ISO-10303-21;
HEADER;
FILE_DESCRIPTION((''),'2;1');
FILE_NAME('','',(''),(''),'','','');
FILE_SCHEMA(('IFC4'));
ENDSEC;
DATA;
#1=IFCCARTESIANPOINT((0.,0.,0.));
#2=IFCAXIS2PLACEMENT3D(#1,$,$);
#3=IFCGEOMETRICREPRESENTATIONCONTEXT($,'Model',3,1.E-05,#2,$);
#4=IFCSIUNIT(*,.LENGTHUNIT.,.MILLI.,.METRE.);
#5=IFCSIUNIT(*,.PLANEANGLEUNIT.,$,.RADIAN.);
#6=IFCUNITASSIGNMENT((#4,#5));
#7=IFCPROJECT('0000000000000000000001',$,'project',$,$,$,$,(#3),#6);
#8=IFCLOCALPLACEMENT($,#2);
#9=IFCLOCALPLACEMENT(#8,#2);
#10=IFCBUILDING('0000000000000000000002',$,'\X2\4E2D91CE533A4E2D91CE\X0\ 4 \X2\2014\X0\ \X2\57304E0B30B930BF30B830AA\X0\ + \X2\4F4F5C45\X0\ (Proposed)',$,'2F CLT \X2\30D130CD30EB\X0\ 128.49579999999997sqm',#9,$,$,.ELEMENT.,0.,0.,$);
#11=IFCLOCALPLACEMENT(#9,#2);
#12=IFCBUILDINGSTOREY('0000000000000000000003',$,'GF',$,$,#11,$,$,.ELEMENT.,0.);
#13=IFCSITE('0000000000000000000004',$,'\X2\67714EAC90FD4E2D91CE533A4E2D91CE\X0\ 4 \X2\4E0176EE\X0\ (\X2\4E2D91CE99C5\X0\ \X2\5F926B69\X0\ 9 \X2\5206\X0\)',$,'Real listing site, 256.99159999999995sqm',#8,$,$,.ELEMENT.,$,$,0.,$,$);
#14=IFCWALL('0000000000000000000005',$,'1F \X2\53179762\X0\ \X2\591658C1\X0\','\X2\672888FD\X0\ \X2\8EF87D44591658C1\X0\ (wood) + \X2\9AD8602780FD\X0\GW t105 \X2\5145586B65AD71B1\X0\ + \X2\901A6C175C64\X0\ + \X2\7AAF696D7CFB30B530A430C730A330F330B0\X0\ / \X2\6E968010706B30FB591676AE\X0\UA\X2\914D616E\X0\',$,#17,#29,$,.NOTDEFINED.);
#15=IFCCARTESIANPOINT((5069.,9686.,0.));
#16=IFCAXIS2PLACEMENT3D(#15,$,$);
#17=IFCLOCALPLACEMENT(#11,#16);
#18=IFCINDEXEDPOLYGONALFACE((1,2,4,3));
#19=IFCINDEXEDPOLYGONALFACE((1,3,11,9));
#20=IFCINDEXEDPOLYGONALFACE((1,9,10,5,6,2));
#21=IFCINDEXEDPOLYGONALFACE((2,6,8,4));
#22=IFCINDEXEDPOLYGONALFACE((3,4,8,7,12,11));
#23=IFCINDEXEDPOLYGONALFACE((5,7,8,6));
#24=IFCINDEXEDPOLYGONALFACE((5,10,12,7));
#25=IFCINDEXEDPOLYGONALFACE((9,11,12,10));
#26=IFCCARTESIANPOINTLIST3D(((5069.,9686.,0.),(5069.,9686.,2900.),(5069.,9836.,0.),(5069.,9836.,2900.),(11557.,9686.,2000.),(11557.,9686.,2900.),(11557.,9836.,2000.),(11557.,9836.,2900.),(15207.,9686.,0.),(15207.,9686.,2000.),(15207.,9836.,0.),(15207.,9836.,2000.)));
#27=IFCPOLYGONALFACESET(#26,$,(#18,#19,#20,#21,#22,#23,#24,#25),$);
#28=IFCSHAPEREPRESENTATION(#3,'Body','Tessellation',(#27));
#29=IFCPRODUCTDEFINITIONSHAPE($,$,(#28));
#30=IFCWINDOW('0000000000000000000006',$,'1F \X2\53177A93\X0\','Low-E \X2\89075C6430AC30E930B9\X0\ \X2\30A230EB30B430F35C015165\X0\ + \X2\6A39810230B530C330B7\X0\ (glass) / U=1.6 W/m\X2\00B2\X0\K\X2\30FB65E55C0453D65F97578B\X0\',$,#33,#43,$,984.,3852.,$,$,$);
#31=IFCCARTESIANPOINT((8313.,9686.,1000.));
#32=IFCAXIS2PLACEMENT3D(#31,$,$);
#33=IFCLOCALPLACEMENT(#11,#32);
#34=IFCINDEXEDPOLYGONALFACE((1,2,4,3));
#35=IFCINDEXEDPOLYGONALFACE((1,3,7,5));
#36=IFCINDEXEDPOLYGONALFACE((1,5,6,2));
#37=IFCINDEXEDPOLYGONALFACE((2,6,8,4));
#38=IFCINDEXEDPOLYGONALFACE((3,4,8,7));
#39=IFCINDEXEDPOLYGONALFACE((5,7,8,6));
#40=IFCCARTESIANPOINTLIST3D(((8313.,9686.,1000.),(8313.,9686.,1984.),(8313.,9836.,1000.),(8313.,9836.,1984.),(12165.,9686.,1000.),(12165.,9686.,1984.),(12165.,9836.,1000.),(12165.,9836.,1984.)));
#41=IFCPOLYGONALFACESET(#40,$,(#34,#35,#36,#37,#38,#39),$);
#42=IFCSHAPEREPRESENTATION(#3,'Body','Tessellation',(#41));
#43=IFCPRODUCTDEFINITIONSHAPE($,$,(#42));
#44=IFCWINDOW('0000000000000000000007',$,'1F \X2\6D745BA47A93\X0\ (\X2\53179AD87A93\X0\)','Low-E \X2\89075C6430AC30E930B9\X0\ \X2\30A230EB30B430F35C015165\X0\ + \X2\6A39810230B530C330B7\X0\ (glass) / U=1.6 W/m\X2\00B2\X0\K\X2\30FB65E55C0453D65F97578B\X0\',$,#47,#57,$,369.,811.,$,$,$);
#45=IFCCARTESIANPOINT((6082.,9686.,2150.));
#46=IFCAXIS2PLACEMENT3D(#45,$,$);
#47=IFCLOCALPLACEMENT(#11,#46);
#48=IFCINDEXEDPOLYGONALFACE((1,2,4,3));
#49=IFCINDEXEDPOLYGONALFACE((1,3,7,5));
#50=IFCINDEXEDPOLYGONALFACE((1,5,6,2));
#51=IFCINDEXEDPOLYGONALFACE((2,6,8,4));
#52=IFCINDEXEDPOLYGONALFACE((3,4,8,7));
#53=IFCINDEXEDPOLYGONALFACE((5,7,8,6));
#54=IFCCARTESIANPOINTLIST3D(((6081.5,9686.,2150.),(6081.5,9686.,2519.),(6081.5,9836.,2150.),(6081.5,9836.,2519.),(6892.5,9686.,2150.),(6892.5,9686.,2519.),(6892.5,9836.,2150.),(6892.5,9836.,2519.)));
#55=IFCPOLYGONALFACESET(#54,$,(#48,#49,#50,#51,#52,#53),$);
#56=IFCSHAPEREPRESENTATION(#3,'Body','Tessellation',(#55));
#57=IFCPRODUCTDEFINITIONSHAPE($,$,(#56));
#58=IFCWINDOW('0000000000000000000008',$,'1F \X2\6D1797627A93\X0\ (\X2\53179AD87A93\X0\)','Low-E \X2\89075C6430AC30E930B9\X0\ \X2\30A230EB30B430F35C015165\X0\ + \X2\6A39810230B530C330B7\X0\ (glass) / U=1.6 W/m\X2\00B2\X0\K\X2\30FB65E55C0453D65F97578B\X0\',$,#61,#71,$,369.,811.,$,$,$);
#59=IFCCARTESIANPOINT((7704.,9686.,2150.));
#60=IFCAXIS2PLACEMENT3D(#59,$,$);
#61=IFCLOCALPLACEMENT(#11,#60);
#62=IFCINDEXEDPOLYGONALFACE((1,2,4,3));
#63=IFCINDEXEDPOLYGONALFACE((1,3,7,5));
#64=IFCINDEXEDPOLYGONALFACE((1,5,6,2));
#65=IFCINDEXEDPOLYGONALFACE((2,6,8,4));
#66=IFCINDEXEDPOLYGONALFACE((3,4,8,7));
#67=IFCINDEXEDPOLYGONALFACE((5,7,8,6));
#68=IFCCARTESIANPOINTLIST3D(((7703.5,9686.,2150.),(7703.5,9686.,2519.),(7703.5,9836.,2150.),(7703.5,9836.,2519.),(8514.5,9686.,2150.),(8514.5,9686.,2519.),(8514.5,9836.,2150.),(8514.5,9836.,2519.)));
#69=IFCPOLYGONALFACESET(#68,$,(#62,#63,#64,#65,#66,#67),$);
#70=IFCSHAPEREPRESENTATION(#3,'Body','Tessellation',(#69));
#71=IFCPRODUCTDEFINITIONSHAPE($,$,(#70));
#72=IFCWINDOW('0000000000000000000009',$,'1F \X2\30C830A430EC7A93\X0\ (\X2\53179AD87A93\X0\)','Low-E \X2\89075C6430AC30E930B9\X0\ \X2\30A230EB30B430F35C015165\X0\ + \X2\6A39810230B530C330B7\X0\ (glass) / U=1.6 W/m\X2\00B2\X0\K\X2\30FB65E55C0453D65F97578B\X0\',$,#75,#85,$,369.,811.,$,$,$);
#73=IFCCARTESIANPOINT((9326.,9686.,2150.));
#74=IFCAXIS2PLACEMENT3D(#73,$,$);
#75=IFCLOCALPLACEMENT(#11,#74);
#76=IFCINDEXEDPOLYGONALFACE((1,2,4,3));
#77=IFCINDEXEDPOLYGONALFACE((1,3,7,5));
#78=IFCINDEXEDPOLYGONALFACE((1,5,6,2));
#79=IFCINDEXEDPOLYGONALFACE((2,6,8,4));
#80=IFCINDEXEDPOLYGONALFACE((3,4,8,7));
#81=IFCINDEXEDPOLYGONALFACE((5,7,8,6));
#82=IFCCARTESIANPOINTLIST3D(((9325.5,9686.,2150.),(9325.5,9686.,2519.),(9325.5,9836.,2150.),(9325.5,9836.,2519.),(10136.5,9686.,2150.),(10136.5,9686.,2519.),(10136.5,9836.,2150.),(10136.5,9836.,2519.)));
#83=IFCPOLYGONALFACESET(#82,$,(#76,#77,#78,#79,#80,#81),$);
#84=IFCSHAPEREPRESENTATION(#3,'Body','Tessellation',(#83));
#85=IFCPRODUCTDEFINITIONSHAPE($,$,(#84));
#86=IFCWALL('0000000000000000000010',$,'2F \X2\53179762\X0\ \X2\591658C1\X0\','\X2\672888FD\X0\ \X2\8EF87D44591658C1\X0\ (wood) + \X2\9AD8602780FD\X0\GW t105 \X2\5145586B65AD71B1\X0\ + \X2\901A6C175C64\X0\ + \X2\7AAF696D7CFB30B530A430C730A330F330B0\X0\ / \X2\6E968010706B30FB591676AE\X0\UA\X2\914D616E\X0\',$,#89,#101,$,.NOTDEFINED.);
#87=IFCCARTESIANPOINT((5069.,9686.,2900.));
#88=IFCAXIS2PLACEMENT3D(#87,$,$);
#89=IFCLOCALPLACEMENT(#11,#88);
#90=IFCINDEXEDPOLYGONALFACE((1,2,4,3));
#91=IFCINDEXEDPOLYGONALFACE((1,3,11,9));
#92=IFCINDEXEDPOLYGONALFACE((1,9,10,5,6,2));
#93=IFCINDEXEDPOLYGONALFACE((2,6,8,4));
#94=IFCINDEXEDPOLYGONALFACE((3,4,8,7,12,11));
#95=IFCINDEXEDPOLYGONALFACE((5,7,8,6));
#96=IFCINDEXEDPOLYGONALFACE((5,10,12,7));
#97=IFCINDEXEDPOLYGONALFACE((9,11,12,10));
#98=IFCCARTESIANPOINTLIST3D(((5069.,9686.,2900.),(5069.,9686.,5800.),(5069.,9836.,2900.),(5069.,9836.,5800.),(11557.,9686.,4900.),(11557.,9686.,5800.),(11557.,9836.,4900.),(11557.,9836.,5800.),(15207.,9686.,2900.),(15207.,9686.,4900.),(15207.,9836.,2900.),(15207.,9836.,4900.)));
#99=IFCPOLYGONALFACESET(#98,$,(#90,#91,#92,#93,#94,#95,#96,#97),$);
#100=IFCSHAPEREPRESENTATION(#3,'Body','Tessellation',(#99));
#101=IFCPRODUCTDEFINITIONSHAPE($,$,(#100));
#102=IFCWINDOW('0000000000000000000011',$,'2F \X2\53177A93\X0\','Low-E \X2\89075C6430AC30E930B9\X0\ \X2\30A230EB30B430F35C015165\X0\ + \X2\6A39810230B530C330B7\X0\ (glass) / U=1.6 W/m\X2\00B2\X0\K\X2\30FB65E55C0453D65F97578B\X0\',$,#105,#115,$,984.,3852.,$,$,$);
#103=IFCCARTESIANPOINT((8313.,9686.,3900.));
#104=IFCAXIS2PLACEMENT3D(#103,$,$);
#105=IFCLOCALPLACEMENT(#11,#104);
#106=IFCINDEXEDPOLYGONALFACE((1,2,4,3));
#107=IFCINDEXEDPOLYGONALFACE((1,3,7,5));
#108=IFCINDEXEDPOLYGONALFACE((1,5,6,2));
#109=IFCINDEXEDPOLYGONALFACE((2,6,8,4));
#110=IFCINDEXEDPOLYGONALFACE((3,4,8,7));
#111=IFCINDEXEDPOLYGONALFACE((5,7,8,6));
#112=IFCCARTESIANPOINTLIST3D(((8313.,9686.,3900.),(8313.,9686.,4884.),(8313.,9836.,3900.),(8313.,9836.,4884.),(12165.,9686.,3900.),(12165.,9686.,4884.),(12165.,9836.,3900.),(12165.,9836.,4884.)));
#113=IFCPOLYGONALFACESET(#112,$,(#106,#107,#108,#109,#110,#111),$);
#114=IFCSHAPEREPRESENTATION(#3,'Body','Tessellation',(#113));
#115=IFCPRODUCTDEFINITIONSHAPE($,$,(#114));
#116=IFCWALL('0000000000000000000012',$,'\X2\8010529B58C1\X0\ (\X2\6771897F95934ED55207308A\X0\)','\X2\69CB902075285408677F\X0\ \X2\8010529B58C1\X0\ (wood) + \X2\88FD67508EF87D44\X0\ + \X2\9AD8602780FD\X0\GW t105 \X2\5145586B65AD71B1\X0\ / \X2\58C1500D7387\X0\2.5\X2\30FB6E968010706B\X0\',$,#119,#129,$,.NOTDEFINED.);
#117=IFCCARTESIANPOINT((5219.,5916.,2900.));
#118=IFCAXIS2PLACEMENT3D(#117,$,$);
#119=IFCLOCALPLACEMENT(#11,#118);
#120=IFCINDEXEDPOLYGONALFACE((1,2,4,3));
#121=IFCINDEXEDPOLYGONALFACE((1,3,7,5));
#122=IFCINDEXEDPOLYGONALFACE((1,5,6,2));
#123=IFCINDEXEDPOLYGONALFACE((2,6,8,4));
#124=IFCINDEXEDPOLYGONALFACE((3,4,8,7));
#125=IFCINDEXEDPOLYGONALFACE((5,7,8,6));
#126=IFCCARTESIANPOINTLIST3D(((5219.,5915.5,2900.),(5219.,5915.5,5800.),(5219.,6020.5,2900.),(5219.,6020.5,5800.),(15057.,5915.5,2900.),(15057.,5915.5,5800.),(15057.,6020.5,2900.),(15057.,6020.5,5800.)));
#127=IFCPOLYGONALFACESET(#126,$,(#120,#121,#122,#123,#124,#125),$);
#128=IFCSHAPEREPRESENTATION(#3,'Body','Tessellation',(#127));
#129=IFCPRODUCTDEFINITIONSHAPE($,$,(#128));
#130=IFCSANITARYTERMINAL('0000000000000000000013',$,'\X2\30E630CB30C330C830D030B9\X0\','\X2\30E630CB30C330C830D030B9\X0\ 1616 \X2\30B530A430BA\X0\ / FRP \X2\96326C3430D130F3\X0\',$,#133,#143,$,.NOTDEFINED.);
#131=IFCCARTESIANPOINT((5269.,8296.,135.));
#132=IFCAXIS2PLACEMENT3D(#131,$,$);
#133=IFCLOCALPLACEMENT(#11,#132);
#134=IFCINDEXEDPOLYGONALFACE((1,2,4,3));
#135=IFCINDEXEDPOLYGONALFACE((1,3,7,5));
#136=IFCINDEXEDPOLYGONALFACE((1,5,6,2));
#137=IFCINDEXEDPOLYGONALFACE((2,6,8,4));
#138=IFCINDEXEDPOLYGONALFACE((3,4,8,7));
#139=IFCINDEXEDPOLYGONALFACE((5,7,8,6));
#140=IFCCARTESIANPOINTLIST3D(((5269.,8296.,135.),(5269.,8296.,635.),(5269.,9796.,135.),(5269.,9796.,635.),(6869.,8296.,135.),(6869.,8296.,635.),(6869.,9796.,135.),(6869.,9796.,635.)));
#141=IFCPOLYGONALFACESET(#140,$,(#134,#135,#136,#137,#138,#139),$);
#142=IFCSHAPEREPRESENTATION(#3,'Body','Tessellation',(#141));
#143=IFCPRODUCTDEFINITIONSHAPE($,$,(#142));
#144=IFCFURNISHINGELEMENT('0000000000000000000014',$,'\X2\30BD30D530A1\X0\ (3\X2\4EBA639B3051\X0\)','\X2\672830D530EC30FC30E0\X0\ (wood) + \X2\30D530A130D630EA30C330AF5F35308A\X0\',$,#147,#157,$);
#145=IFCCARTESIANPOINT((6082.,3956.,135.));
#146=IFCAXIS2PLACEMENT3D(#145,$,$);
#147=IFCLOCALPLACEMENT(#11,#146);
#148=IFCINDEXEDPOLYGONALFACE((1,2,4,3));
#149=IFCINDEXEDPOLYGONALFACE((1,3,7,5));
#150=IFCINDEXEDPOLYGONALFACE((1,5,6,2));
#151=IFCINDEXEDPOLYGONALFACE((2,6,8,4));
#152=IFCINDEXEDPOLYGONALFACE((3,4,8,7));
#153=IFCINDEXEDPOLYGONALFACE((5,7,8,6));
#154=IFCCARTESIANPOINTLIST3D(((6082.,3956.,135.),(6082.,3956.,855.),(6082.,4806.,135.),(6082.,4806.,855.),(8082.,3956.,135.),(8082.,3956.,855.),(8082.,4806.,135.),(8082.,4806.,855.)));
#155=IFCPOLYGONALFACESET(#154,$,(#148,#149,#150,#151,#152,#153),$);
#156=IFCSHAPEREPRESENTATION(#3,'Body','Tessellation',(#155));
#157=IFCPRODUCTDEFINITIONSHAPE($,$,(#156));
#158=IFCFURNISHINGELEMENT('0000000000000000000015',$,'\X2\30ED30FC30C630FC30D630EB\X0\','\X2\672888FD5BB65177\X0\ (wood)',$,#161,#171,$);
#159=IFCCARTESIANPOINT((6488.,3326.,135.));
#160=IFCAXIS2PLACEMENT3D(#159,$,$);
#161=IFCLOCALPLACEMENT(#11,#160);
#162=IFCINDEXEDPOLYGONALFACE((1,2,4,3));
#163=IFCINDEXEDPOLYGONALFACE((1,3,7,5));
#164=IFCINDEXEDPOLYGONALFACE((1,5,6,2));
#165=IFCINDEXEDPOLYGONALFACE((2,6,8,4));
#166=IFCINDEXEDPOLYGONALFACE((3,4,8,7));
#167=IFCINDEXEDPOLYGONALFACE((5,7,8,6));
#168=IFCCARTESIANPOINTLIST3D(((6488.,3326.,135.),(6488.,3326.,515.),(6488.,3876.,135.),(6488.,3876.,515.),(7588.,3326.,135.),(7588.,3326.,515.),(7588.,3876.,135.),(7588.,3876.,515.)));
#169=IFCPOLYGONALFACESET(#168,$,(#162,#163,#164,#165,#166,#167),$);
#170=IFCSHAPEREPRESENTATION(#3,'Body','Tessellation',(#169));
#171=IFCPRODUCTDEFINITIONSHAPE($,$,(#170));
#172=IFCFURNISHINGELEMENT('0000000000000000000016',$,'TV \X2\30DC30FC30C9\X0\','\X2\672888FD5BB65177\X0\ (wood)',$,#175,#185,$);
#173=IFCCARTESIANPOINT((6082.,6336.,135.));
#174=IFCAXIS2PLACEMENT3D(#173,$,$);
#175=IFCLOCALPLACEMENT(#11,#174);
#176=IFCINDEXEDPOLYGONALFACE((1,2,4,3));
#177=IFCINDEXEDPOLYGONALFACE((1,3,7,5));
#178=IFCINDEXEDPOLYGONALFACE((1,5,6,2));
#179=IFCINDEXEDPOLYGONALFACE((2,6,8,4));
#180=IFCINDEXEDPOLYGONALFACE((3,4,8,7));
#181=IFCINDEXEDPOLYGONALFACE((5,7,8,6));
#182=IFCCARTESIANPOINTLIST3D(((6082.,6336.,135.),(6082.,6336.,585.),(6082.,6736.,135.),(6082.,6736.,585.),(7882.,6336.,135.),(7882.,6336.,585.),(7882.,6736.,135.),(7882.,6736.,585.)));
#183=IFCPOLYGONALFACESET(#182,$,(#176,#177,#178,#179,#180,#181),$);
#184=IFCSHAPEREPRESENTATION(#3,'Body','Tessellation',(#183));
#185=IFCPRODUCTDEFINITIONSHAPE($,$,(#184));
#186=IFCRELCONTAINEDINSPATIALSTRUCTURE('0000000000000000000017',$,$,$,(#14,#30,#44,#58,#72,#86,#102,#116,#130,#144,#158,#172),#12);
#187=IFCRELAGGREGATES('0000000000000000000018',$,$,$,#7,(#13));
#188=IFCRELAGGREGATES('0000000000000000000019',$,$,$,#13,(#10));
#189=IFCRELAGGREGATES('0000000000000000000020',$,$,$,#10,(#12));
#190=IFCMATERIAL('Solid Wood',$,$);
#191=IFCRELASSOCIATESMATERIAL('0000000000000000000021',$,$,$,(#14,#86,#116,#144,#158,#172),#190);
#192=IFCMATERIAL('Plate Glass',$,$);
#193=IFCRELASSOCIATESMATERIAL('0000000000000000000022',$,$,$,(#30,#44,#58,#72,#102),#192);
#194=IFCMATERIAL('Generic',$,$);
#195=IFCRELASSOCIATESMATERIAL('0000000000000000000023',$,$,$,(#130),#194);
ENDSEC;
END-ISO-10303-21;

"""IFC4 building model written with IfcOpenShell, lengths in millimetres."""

from ifc_helpers import new_model, si_unit, frame, frame_2d, origin, place, context, project, spatial, rectangle, extrude, material, element, fill, save


model = new_model("IFC4")

# Units and contexts
model_context = context("Model", 3, precision=1e-05, world=origin())
ifc_project = project(units=[si_unit("LENGTHUNIT", "METRE", prefix="MILLI"), si_unit("PLANEANGLEUNIT", "RADIAN")], contexts=[model_context])

# Site, building, storey
site_placement = place(None, origin())
site = spatial("IfcSite", under=ifc_project, at=site_placement, Name="東京都中野区中野 4 丁目 (中野駅 徒歩 9 分)", ObjectType="Real listing site, 256.99159999999995sqm", CompositionType="ELEMENT", RefElevation=0.0)
building_placement = place(site_placement, origin())
building = spatial("IfcBuilding", under=site, at=building_placement, Name="中野区中野 4 — 地下スタジオ + 住居 (Proposed)", ObjectType="2F CLT パネル 128.49579999999997sqm", CompositionType="ELEMENT", ElevationOfRefHeight=0.0, ElevationOfTerrain=0.0)
storey_placement = place(building_placement, origin())
storey = spatial("IfcBuildingStorey", under=building, at=storey_placement, Name="GF", CompositionType="ELEMENT", Elevation=0.0)

# Wall, openings, windows
ifc_material_1 = material(Name="Solid Wood")
wall_1_placement = place(storey_placement, frame((5069.0, 9686.0, 0.0)))
wall_1 = element("IfcWall", 1, at=wall_1_placement, inside=storey, material=ifc_material_1, Name="1F 北面 外壁", Description="木製 軸組外壁 (wood) + 高性能GW t105 充填断熱 + 通気層 + 窯業系サイディング / 準耐火・外皮UA配慮", PredefinedType="NOTDEFINED", context=model_context, shape_type="SweptSolid", body=[
    extrude(rectangle(XDim=10138.0, YDim=150.0, at=frame_2d((5069.0, 75.0))), frame((5069.0, 9686.0, 0.0)), (0.0, 0.0, 1.0), 2900.0),
])
opening_1_placement = place(storey_placement, frame((8313.0, 9686.0, 1000.0)))
opening_1 = element("IfcOpeningElement", 2, at=opening_1_placement, cuts=wall_1, PredefinedType="NOTDEFINED", context=model_context, shape_type="SweptSolid", body=[
    extrude(rectangle(XDim=3852.0, YDim=150.0, at=frame_2d((1926.0, 75.0))), frame((8313.0, 9686.0, 1000.0)), (0.0, 0.0, 1.0), 984.0),
])
opening_2_placement = place(storey_placement, frame((6082.0, 9686.0, 2150.0)))
opening_2 = element("IfcOpeningElement", 3, at=opening_2_placement, cuts=wall_1, PredefinedType="NOTDEFINED", context=model_context, shape_type="SweptSolid", body=[
    extrude(rectangle(XDim=811.0, YDim=150.0, at=frame_2d((405.0, 75.0))), frame((6082.0, 9686.0, 2150.0)), (0.0, 0.0, 1.0), 369.0),
])
opening_3_placement = place(storey_placement, frame((7704.0, 9686.0, 2150.0)))
opening_3 = element("IfcOpeningElement", 4, at=opening_3_placement, cuts=wall_1, PredefinedType="NOTDEFINED", context=model_context, shape_type="SweptSolid", body=[
    extrude(rectangle(XDim=811.0, YDim=150.0, at=frame_2d((405.0, 75.0))), frame((7704.0, 9686.0, 2150.0)), (0.0, 0.0, 1.0), 369.0),
])
opening_4_placement = place(storey_placement, frame((9326.0, 9686.0, 2150.0)))
opening_4 = element("IfcOpeningElement", 5, at=opening_4_placement, cuts=wall_1, PredefinedType="NOTDEFINED", context=model_context, shape_type="SweptSolid", body=[
    extrude(rectangle(XDim=811.0, YDim=150.0, at=frame_2d((405.0, 75.0))), frame((9326.0, 9686.0, 2150.0)), (0.0, 0.0, 1.0), 369.0),
])
ifc_material_2 = material(Name="Plate Glass")
window_1_placement = place(storey_placement, frame((8313.0, 9686.0, 1000.0)))
window_1 = element("IfcWindow", 6, at=window_1_placement, inside=storey, material=ifc_material_2, Name="1F 北窓", Description="Low-E 複層ガラス アルゴン封入 + 樹脂サッシ (glass) / U=1.6 W/m²K・日射取得型", OverallHeight=984.0, OverallWidth=3852.0, context=model_context, shape_type="SweptSolid", body=[
    extrude(rectangle(XDim=3852.0, YDim=150.0, at=frame_2d((1926.0, 75.0))), frame((8313.0, 9686.0, 1000.0)), (0.0, 0.0, 1.0), 984.0),
])
fill(opening_1, window_1)
window_2_placement = place(storey_placement, frame((6082.0, 9686.0, 2150.0)))
window_2 = element("IfcWindow", 7, at=window_2_placement, inside=storey, material=ifc_material_2, Name="1F 浴室窓 (北高窓)", Description="Low-E 複層ガラス アルゴン封入 + 樹脂サッシ (glass) / U=1.6 W/m²K・日射取得型", OverallHeight=369.0, OverallWidth=811.0, context=model_context, shape_type="SweptSolid", body=[
    extrude(rectangle(XDim=811.0, YDim=150.0, at=frame_2d((405.0, 75.0))), frame((6082.0, 9686.0, 2150.0)), (0.0, 0.0, 1.0), 369.0),
])
fill(opening_2, window_2)
window_3_placement = place(storey_placement, frame((7704.0, 9686.0, 2150.0)))
window_3 = element("IfcWindow", 8, at=window_3_placement, inside=storey, material=ifc_material_2, Name="1F 洗面窓 (北高窓)", Description="Low-E 複層ガラス アルゴン封入 + 樹脂サッシ (glass) / U=1.6 W/m²K・日射取得型", OverallHeight=369.0, OverallWidth=811.0, context=model_context, shape_type="SweptSolid", body=[
    extrude(rectangle(XDim=811.0, YDim=150.0, at=frame_2d((405.0, 75.0))), frame((7704.0, 9686.0, 2150.0)), (0.0, 0.0, 1.0), 369.0),
])
fill(opening_3, window_3)
window_4_placement = place(storey_placement, frame((9326.0, 9686.0, 2150.0)))
window_4 = element("IfcWindow", 9, at=window_4_placement, inside=storey, material=ifc_material_2, Name="1F トイレ窓 (北高窓)", Description="Low-E 複層ガラス アルゴン封入 + 樹脂サッシ (glass) / U=1.6 W/m²K・日射取得型", OverallHeight=369.0, OverallWidth=811.0, context=model_context, shape_type="SweptSolid", body=[
    extrude(rectangle(XDim=811.0, YDim=150.0, at=frame_2d((405.0, 75.0))), frame((9326.0, 9686.0, 2150.0)), (0.0, 0.0, 1.0), 369.0),
])
fill(opening_4, window_4)

# Wall, opening, window
wall_2_placement = place(storey_placement, frame((5069.0, 9686.0, 2900.0)))
wall_2 = element("IfcWall", 10, at=wall_2_placement, inside=storey, material=ifc_material_1, Name="2F 北面 外壁", Description="木製 軸組外壁 (wood) + 高性能GW t105 充填断熱 + 通気層 + 窯業系サイディング / 準耐火・外皮UA配慮", PredefinedType="NOTDEFINED", context=model_context, shape_type="SweptSolid", body=[
    extrude(rectangle(XDim=10138.0, YDim=150.0, at=frame_2d((5069.0, 75.0))), frame((5069.0, 9686.0, 2900.0)), (0.0, 0.0, 1.0), 2900.0),
])
opening_5_placement = place(storey_placement, frame((8313.0, 9686.0, 3900.0)))
opening_5 = element("IfcOpeningElement", 11, at=opening_5_placement, cuts=wall_2, PredefinedType="NOTDEFINED", context=model_context, shape_type="SweptSolid", body=[
    extrude(rectangle(XDim=3852.0, YDim=150.0, at=frame_2d((1926.0, 75.0))), frame((8313.0, 9686.0, 3900.0)), (0.0, 0.0, 1.0), 984.0),
])
window_5_placement = place(storey_placement, frame((8313.0, 9686.0, 3900.0)))
window_5 = element("IfcWindow", 12, at=window_5_placement, inside=storey, material=ifc_material_2, Name="2F 北窓", Description="Low-E 複層ガラス アルゴン封入 + 樹脂サッシ (glass) / U=1.6 W/m²K・日射取得型", OverallHeight=984.0, OverallWidth=3852.0, context=model_context, shape_type="SweptSolid", body=[
    extrude(rectangle(XDim=3852.0, YDim=150.0, at=frame_2d((1926.0, 75.0))), frame((8313.0, 9686.0, 3900.0)), (0.0, 0.0, 1.0), 984.0),
])
fill(opening_5, window_5)

# Wall
wall_3_placement = place(storey_placement, frame((5219.0, 5916.0, 2900.0)))
element("IfcWall", 13, at=wall_3_placement, inside=storey, material=ifc_material_1, Name="耐力壁 (東西間仕切り)", Description="構造用合板 耐力壁 (wood) + 製材軸組 + 高性能GW t105 充填断熱 / 壁倍率2.5・準耐火", PredefinedType="NOTDEFINED", context=model_context, shape_type="SweptSolid", body=[
    extrude(rectangle(XDim=9838.0, YDim=105.0, at=frame_2d((4919.0, 52.0))), frame((5219.0, 5916.0, 2900.0)), (0.0, 0.0, 1.0), 2900.0),
])

# Sanitary terminal
ifc_material_3 = material(Name="Generic")
sanitary_terminal_placement = place(storey_placement, frame((5269.0, 8296.0, 135.0)))
element("IfcSanitaryTerminal", 14, at=sanitary_terminal_placement, inside=storey, material=ifc_material_3, Name="ユニットバス", Description="ユニットバス 1616 サイズ / FRP 防水パン", PredefinedType="NOTDEFINED", context=model_context, shape_type="SweptSolid", body=[
    extrude(rectangle(XDim=1600.0, YDim=1500.0, at=frame_2d((800.0, 750.0))), frame((5269.0, 8296.0, 135.0)), (0.0, 0.0, 1.0), 500.0),
])

# Furnishing elements
furnishing_1_placement = place(storey_placement, frame((6082.0, 3956.0, 135.0)))
element("IfcFurnishingElement", 15, at=furnishing_1_placement, inside=storey, material=ifc_material_1, Name="ソファ (3人掛け)", Description="木フレーム (wood) + ファブリック張り", context=model_context, shape_type="SweptSolid", body=[
    extrude(rectangle(XDim=2000.0, YDim=850.0, at=frame_2d((1000.0, 425.0))), frame((6082.0, 3956.0, 135.0)), (0.0, 0.0, 1.0), 720.0),
])
furnishing_2_placement = place(storey_placement, frame((6488.0, 3326.0, 135.0)))
element("IfcFurnishingElement", 16, at=furnishing_2_placement, inside=storey, material=ifc_material_1, Name="ローテーブル", Description="木製家具 (wood)", context=model_context, shape_type="SweptSolid", body=[
    extrude(rectangle(XDim=1100.0, YDim=550.0, at=frame_2d((550.0, 275.0))), frame((6488.0, 3326.0, 135.0)), (0.0, 0.0, 1.0), 380.0),
])
furnishing_3_placement = place(storey_placement, frame((6082.0, 6336.0, 135.0)))
element("IfcFurnishingElement", 17, at=furnishing_3_placement, inside=storey, material=ifc_material_1, Name="TV ボード", Description="木製家具 (wood)", context=model_context, shape_type="SweptSolid", body=[
    extrude(rectangle(XDim=1800.0, YDim=400.0, at=frame_2d((900.0, 200.0))), frame((6082.0, 6336.0, 135.0)), (0.0, 0.0, 1.0), 450.0),
])

save(model, "model.ifc")
